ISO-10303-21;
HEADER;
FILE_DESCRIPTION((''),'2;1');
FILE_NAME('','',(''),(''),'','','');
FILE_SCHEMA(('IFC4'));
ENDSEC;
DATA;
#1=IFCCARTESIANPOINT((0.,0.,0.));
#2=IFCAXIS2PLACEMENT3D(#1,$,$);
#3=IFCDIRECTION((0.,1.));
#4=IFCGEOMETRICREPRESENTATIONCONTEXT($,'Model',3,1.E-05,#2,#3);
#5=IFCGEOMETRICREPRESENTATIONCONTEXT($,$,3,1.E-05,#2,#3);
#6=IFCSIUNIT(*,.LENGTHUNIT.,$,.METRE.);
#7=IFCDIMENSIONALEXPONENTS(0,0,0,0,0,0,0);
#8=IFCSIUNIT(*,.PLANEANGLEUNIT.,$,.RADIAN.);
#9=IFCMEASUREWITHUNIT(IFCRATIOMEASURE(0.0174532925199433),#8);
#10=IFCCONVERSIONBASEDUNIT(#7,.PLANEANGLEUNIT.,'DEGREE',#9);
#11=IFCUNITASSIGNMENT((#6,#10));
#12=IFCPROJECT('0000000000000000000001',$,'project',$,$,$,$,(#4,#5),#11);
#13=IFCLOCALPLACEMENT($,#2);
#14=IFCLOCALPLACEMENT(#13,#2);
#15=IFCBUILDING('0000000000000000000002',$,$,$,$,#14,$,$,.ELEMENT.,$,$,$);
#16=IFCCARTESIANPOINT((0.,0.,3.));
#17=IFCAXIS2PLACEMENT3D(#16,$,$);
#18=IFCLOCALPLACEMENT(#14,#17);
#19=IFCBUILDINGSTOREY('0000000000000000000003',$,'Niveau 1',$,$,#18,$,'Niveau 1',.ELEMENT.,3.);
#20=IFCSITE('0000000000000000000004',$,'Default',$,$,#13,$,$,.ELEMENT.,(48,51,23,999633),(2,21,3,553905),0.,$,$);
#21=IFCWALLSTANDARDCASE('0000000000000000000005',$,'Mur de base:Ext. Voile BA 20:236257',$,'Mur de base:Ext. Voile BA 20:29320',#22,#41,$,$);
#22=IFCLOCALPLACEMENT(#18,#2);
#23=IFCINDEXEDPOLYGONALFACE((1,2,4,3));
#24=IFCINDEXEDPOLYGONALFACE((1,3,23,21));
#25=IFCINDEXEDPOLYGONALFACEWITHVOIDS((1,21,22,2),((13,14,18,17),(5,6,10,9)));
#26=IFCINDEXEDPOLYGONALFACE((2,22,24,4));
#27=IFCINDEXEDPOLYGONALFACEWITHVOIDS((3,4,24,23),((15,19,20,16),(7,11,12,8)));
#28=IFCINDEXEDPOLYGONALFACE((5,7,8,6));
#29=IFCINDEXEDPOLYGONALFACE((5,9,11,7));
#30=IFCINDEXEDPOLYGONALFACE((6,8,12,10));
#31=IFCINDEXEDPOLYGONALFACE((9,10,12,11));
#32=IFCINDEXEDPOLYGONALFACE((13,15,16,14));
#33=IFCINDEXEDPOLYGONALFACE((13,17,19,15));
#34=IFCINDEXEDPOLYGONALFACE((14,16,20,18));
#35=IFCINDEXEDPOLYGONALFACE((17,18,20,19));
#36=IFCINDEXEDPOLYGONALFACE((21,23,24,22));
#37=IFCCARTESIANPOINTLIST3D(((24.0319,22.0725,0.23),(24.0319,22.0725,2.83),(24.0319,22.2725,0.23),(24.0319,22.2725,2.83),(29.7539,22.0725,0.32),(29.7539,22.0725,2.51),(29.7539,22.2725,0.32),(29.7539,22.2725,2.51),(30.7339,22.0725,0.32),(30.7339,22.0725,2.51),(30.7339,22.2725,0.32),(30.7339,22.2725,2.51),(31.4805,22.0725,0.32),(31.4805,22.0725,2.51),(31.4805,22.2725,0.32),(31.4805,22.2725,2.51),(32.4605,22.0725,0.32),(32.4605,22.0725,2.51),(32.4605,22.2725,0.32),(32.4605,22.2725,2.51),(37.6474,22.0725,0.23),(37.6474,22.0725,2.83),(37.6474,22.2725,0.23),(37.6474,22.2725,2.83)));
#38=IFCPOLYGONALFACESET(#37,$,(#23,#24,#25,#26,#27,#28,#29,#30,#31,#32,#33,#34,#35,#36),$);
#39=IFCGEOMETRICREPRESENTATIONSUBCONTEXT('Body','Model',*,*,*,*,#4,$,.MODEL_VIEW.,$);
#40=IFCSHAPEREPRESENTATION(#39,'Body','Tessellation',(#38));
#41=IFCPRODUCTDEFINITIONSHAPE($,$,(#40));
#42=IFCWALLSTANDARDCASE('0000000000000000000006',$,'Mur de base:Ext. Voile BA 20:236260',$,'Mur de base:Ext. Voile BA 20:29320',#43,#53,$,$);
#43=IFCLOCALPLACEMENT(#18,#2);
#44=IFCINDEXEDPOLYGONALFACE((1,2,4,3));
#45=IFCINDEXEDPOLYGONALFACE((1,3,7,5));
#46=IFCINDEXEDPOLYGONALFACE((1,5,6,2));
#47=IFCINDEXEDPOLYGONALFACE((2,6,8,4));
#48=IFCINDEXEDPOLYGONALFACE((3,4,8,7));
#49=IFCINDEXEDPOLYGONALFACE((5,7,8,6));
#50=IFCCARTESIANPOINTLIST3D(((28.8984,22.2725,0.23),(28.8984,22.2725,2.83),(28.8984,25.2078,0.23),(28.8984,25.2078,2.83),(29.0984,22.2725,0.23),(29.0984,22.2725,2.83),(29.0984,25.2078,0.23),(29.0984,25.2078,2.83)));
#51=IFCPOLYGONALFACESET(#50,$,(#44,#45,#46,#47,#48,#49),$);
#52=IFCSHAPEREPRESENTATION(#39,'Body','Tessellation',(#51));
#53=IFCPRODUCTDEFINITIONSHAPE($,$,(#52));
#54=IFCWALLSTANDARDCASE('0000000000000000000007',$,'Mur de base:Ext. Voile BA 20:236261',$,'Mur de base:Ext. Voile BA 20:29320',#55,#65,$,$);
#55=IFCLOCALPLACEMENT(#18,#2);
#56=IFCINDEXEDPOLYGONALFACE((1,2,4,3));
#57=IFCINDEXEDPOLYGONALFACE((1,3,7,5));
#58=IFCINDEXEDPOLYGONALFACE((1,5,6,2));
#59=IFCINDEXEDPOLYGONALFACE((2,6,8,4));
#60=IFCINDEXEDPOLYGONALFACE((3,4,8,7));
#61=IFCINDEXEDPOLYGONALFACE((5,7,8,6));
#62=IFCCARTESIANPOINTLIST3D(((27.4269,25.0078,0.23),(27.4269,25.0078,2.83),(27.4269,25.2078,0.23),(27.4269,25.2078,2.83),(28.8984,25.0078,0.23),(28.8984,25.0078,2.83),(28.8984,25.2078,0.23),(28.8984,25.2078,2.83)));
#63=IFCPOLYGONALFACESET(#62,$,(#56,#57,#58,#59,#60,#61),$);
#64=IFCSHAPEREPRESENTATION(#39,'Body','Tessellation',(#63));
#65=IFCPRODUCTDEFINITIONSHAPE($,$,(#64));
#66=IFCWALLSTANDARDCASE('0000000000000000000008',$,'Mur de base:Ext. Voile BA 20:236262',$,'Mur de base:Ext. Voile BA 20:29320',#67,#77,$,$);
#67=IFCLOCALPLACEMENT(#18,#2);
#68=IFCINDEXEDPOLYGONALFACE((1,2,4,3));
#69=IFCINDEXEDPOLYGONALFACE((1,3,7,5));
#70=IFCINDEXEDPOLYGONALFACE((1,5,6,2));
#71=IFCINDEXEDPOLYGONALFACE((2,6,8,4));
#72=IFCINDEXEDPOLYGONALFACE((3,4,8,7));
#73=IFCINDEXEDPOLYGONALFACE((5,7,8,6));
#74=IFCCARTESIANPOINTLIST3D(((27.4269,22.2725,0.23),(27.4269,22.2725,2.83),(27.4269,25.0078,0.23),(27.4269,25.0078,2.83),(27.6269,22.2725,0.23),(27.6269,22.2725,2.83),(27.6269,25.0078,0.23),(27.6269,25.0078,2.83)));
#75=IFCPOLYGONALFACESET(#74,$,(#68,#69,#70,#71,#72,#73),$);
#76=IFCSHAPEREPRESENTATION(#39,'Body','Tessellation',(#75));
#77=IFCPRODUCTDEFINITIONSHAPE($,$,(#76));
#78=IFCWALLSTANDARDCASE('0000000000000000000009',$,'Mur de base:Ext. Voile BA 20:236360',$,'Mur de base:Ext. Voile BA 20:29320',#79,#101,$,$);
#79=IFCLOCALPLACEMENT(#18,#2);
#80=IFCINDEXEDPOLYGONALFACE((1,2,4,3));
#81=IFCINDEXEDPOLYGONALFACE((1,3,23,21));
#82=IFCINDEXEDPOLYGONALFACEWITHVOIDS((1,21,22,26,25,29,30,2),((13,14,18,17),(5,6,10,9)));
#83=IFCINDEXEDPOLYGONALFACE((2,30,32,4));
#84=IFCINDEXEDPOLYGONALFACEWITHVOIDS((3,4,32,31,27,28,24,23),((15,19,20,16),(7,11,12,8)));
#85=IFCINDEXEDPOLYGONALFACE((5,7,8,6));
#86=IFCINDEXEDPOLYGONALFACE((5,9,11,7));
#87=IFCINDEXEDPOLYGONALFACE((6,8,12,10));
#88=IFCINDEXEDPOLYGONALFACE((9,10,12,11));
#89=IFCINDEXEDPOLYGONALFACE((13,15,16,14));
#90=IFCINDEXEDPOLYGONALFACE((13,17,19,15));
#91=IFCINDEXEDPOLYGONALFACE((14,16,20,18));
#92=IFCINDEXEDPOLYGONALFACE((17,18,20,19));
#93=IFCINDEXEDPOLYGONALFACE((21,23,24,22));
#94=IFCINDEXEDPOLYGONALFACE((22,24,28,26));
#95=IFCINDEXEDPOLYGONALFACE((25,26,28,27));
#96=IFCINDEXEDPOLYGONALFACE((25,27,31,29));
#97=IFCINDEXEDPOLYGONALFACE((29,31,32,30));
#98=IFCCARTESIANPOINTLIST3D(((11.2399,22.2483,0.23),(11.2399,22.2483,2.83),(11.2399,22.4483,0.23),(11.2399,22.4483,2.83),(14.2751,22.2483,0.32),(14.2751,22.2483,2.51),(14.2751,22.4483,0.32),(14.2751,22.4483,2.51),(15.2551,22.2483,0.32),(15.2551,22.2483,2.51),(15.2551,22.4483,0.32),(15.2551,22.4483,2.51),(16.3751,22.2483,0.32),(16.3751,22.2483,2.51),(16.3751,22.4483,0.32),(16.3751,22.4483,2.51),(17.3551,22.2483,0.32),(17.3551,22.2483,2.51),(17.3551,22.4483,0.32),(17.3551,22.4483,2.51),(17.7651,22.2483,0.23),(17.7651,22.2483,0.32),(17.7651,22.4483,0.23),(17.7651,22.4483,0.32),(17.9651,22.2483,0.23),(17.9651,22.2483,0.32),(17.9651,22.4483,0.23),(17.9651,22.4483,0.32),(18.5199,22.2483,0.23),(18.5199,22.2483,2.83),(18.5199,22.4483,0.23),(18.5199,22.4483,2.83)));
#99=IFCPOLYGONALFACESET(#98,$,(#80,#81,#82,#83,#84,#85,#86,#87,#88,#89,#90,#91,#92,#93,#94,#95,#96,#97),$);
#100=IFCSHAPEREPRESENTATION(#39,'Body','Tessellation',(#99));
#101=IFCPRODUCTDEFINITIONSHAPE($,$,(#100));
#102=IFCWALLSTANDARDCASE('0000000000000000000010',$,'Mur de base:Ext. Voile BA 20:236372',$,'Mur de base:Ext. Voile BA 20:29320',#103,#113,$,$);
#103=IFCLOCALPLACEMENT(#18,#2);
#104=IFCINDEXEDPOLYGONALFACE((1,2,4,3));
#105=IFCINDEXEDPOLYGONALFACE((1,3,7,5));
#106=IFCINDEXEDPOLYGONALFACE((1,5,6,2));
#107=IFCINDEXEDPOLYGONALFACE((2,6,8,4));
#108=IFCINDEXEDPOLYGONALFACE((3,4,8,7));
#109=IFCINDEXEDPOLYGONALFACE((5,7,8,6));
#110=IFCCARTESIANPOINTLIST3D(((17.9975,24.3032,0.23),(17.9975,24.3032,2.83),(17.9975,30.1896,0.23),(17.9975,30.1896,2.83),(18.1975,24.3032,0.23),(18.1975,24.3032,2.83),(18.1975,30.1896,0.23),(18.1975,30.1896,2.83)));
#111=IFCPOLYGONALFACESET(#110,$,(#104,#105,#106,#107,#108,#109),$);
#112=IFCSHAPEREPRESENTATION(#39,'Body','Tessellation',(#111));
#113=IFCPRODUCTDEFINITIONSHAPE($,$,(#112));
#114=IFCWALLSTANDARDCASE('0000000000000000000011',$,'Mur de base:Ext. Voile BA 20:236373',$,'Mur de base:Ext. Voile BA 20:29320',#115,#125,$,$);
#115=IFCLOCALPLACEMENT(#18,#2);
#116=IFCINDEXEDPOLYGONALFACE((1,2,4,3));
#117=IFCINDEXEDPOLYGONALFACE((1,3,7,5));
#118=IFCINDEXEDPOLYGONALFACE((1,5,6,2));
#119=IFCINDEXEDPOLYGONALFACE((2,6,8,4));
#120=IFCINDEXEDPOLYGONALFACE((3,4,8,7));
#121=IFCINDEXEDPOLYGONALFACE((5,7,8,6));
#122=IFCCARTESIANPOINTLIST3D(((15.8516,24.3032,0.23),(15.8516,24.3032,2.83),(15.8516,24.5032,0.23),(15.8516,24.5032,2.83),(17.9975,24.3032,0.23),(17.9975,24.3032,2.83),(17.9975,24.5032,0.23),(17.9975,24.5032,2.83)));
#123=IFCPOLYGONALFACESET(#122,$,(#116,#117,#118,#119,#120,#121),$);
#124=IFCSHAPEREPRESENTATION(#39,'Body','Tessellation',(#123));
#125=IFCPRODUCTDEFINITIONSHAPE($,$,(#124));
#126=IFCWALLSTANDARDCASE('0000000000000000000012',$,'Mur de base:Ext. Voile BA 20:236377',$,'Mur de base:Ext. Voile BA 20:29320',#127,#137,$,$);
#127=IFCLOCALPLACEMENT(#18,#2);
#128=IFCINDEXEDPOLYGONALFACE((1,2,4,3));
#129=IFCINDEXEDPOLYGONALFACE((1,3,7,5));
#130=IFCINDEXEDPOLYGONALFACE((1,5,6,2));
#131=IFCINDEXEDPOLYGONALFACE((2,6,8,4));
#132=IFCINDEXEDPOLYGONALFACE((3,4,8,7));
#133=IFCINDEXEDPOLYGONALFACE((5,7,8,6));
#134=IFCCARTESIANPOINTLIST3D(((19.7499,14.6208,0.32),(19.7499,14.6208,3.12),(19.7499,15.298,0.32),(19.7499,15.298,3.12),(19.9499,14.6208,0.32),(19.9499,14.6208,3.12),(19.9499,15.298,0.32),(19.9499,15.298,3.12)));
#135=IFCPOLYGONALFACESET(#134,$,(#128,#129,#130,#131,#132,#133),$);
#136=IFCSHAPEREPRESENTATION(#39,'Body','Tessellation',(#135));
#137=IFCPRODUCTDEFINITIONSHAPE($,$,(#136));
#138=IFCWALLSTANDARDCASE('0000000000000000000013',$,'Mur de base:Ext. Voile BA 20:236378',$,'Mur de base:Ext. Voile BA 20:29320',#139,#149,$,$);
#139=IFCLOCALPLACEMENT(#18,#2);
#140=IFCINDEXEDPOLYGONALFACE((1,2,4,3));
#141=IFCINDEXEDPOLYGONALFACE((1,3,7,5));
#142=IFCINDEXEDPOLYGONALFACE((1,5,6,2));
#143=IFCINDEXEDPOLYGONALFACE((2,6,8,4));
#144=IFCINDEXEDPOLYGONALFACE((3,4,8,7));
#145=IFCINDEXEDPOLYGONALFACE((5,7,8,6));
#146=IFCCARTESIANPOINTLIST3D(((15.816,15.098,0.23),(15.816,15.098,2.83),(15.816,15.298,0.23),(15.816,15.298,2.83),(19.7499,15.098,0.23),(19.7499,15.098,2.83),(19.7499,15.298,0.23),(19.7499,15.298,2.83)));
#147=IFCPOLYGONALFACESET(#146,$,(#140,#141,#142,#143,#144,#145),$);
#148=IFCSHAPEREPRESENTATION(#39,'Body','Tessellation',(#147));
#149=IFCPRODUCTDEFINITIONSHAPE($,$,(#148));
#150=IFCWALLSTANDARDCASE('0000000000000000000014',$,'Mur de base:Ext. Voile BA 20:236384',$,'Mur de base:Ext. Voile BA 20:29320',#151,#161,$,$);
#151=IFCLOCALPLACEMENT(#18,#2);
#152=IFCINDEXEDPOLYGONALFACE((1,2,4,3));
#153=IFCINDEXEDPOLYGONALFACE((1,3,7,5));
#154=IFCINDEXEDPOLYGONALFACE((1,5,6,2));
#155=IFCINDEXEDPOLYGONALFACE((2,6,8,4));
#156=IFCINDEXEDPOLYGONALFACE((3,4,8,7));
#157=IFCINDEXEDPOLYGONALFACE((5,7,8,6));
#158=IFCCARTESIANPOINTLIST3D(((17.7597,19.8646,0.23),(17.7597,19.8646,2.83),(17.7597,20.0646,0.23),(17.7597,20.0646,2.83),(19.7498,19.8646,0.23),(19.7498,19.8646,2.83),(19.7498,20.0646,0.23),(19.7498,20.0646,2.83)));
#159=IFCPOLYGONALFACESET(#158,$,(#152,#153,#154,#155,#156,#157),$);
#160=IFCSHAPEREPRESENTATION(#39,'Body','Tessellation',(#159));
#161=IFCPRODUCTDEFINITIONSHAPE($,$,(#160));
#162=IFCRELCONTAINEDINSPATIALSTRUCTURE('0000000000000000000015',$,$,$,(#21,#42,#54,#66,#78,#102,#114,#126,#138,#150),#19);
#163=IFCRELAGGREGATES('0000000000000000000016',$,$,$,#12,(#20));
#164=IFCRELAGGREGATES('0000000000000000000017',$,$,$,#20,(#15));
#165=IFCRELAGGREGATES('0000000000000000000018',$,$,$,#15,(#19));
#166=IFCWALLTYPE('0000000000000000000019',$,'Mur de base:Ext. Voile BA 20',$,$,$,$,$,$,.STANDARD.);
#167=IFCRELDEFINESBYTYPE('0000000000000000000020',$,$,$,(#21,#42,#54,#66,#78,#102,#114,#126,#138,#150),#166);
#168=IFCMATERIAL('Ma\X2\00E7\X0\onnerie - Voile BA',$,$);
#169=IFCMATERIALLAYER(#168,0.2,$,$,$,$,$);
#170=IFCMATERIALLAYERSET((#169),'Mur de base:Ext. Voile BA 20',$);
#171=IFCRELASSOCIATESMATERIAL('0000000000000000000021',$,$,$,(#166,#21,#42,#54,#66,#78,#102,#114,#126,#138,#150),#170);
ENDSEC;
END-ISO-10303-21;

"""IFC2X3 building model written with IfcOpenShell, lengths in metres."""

from ifc_helpers import new_model, entity, si_unit, converted_unit, direction, frame, frame_2d, origin, origin_2d_with_axis, place, context, subcontext, project, spatial, polyline, rectangle, extrude, clip, bounded_halfspace, material, layer, layer_set, layer_usage, type_object, element, save


model = new_model("IFC2X3")

# Units and contexts
model_context = context("Model", 3, precision=1e-05, world=origin(), true_north=direction((0.0, 1.0)))
context_of_model = context(None, 3, precision=1e-05, world=origin(), true_north=direction((0.0, 1.0)))
body_context = subcontext(model_context, "Body", "Model", "MODEL_VIEW")
ifc_project = project(units=[si_unit("LENGTHUNIT", "METRE"), converted_unit("PLANEANGLEUNIT", "DEGREE", entity("IfcRatioMeasure", 0.0174532925199433), si_unit("PLANEANGLEUNIT", "RADIAN"), dimensions=[0, 0, 0, 0, 0, 0, 0])], contexts=[model_context, context_of_model])

# Site, building, storey
site_placement = place(None, origin())
site = spatial("IfcSite", under=ifc_project, at=site_placement, Name="Default", CompositionType="ELEMENT", RefLatitude=(48, 51, 23, 999633), RefLongitude=(2, 21, 3, 553905), RefElevation=0.0)
building_placement = place(site_placement, origin())
building = spatial("IfcBuilding", under=site, at=building_placement, CompositionType="ELEMENT")
storey_placement = place(building_placement, frame((0.0, 0.0, 3.0)))
storey = spatial("IfcBuildingStorey", under=building, at=storey_placement, Name="Niveau 1", LongName="Niveau 1", CompositionType="ELEMENT", Elevation=3.0)

# Wall, openings
ifc_material = material(Name="Maçonnerie - Voile BA")
ifc_layer_1 = layer(ifc_material, 0.2)
ifc_layer_set_1 = layer_set([ifc_layer_1], Name="Mur de base:Ext. Voile BA 20")
ifc_layer_usage_1 = layer_usage(ifc_layer_set_1, "AXIS2", "NEGATIVE", 0.1)
wall_type_1 = type_object("IfcWallType", Name="Mur de base:Ext. Voile BA 20", PredefinedType="STANDARD", material=ifc_layer_set_1)
wall_1_placement = place(storey_placement, frame((24.0319, 22.1725, 0.23)))
wall_1 = element("IfcWallStandardCase", 1, at=wall_1_placement, inside=storey, type_object=wall_type_1, material=ifc_layer_usage_1, Name="Mur de base:Ext. Voile BA 20:236257", ObjectType="Mur de base:Ext. Voile BA 20:29320", context=body_context, shape_type="SweptSolid", body=[
    extrude(rectangle(XDim=13.6155, YDim=0.2, at=frame_2d((6.8077, 0.0), x_axis=(-1.0, 0.0))), origin(), (0.0, 0.0, 1.0), 2.6),
])
opening_1_placement = place(wall_1_placement, origin())
element("IfcOpeningElement", 2, at=opening_1_placement, cuts=wall_1, ObjectType="Opening", context=body_context, shape_type="SweptSolid", body=[
    extrude(rectangle(XDim=2.19, YDim=0.98, at=origin_2d_with_axis()), frame((7.9385, -0.1, 1.185), z_axis=(0.0, 1.0, 0.0), x_axis=(0.0, 0.0, -1.0)), (0.0, 0.0, 1.0), 0.2),
])
opening_2_placement = place(wall_1_placement, origin())
element("IfcOpeningElement", 3, at=opening_2_placement, cuts=wall_1, ObjectType="Opening", context=body_context, shape_type="SweptSolid", body=[
    extrude(rectangle(XDim=2.19, YDim=0.98, at=origin_2d_with_axis()), frame((6.212, -0.1, 1.185), z_axis=(0.0, 1.0, 0.0), x_axis=(0.0, 0.0, -1.0)), (0.0, 0.0, 1.0), 0.2),
])

# Walls
ifc_layer_usage_2 = layer_usage(ifc_layer_set_1, "AXIS2", "NEGATIVE", 0.1)
wall_2_placement = place(storey_placement, frame((28.9984, 22.2725, 0.23), z_axis=(0.0, 0.0, 1.0), x_axis=(0.0, 1.0, 0.0)))
element("IfcWallStandardCase", 4, at=wall_2_placement, inside=storey, type_object=wall_type_1, material=ifc_layer_usage_2, Name="Mur de base:Ext. Voile BA 20:236260", ObjectType="Mur de base:Ext. Voile BA 20:29320", context=body_context, shape_type="SweptSolid", body=[
    extrude(rectangle(XDim=2.9353, YDim=0.2, at=frame_2d((1.4677, 0.0), x_axis=(-1.0, 0.0))), origin(), (0.0, 0.0, 1.0), 2.6),
])
ifc_layer_usage_3 = layer_usage(ifc_layer_set_1, "AXIS2", "NEGATIVE", 0.1)
wall_3_placement = place(storey_placement, frame((28.8984, 25.1078, 0.23), z_axis=(0.0, 0.0, 1.0), x_axis=(-1.0, 0.0, 0.0)))
element("IfcWallStandardCase", 5, at=wall_3_placement, inside=storey, type_object=wall_type_1, material=ifc_layer_usage_3, Name="Mur de base:Ext. Voile BA 20:236261", ObjectType="Mur de base:Ext. Voile BA 20:29320", context=body_context, shape_type="SweptSolid", body=[
    extrude(rectangle(XDim=1.4714, YDim=0.2, at=frame_2d((0.7357, 0.0), x_axis=(-1.0, 0.0))), origin(), (0.0, 0.0, 1.0), 2.6),
])
ifc_layer_usage_4 = layer_usage(ifc_layer_set_1, "AXIS2", "NEGATIVE", 0.1)
wall_4_placement = place(storey_placement, frame((27.5269, 25.0078, 0.23), z_axis=(0.0, 0.0, 1.0), x_axis=(0.0, -1.0, 0.0)))
element("IfcWallStandardCase", 6, at=wall_4_placement, inside=storey, type_object=wall_type_1, material=ifc_layer_usage_4, Name="Mur de base:Ext. Voile BA 20:236262", ObjectType="Mur de base:Ext. Voile BA 20:29320", context=body_context, shape_type="SweptSolid", body=[
    extrude(rectangle(XDim=2.7353, YDim=0.2, at=frame_2d((1.3677, 0.0), x_axis=(-1.0, 0.0))), origin(), (0.0, 0.0, 1.0), 2.6),
])

# Wall, openings
ifc_layer_usage_5 = layer_usage(ifc_layer_set_1, "AXIS2", "NEGATIVE", 0.1)
wall_5_placement = place(storey_placement, frame((18.5199, 22.3483, 0.23), z_axis=(0.0, 0.0, 1.0), x_axis=(-1.0, 0.0, 0.0)))
wall_5 = element("IfcWallStandardCase", 7, at=wall_5_placement, inside=storey, type_object=wall_type_1, material=ifc_layer_usage_5, Name="Mur de base:Ext. Voile BA 20:236360", ObjectType="Mur de base:Ext. Voile BA 20:29320", context=body_context, shape_type="Clipping", body=[
    clip(extrude(rectangle(XDim=7.28, YDim=0.2, at=frame_2d((3.64, 0.0), x_axis=(-1.0, 0.0))), origin(), (0.0, 0.0, 1.0), 2.6), bounded_halfspace(frame((0.7548, 0.1, 0.09), z_axis=(0.0, 0.0, 1.0), x_axis=(-1.0, 0.0, 0.0)), True, frame((0.7548, 0.1, 0.09), z_axis=(0.0, 0.0, 1.0), x_axis=(-1.0, 0.0, 0.0)), polyline([(0.0, 0.0), (0.2, 0.0), (0.2, 0.2), (0.0, 0.2), (0.0, 0.0)]))),
])
opening_3_placement = place(wall_5_placement, origin())
element("IfcOpeningElement", 8, at=opening_3_placement, cuts=wall_5, ObjectType="Opening", context=body_context, shape_type="SweptSolid", body=[
    extrude(rectangle(XDim=2.19, YDim=0.98, at=origin_2d_with_axis()), frame((3.7548, -0.1, 1.185), z_axis=(0.0, 1.0, 0.0), x_axis=(0.0, 0.0, -1.0)), (0.0, 0.0, 1.0), 0.2),
])
opening_4_placement = place(wall_5_placement, origin())
element("IfcOpeningElement", 9, at=opening_4_placement, cuts=wall_5, ObjectType="Opening", context=body_context, shape_type="SweptSolid", body=[
    extrude(rectangle(XDim=2.19, YDim=0.98, at=frame_2d((0.0, 0.0), x_axis=(1.0, 0.0))), frame((1.6548, -0.1, 1.185), z_axis=(0.0, 1.0, 0.0), x_axis=(0.0, 0.0, -1.0)), (0.0, 0.0, 1.0), 0.2),
])

# Walls
ifc_layer_usage_6 = layer_usage(ifc_layer_set_1, "AXIS2", "NEGATIVE", 0.1)
wall_6_placement = place(storey_placement, frame((18.0975, 30.1896, 0.23), z_axis=(0.0, 0.0, 1.0), x_axis=(0.0, -1.0, 0.0)))
element("IfcWallStandardCase", 10, at=wall_6_placement, inside=storey, type_object=wall_type_1, material=ifc_layer_usage_6, Name="Mur de base:Ext. Voile BA 20:236372", ObjectType="Mur de base:Ext. Voile BA 20:29320", context=body_context, shape_type="SweptSolid", body=[
    extrude(rectangle(XDim=5.8865, YDim=0.2, at=frame_2d((2.9432, 0.0), x_axis=(-1.0, 0.0))), origin(), (0.0, 0.0, 1.0), 2.6),
])
ifc_layer_usage_7 = layer_usage(ifc_layer_set_1, "AXIS2", "NEGATIVE", 0.1)
wall_7_placement = place(storey_placement, frame((17.9975, 24.4032, 0.23), z_axis=(0.0, 0.0, 1.0), x_axis=(-1.0, 0.0, 0.0)))
element("IfcWallStandardCase", 11, at=wall_7_placement, inside=storey, type_object=wall_type_1, material=ifc_layer_usage_7, Name="Mur de base:Ext. Voile BA 20:236373", ObjectType="Mur de base:Ext. Voile BA 20:29320", context=body_context, shape_type="SweptSolid", body=[
    extrude(rectangle(XDim=2.146, YDim=0.2, at=frame_2d((1.073, 0.0), x_axis=(-1.0, 0.0))), origin(), (0.0, 0.0, 1.0), 2.6),
])
ifc_layer_usage_8 = layer_usage(ifc_layer_set_1, "AXIS2", "NEGATIVE", 0.1)
wall_8_placement = place(storey_placement, frame((19.8499, 14.6208, 0.32), z_axis=(0.0, 0.0, 1.0), x_axis=(0.0, 1.0, 0.0)))
element("IfcWallStandardCase", 12, at=wall_8_placement, inside=storey, type_object=wall_type_1, material=ifc_layer_usage_8, Name="Mur de base:Ext. Voile BA 20:236377", ObjectType="Mur de base:Ext. Voile BA 20:29320", context=body_context, shape_type="SweptSolid", body=[
    extrude(rectangle(XDim=0.6771, YDim=0.2, at=frame_2d((0.3386, 0.0), x_axis=(-1.0, 0.0))), origin(), (0.0, 0.0, 1.0), 2.8),
])
ifc_layer_usage_9 = layer_usage(ifc_layer_set_1, "AXIS2", "NEGATIVE", 0.1)
wall_9_placement = place(storey_placement, frame((19.7499, 15.198, 0.23), z_axis=(0.0, 0.0, 1.0), x_axis=(-1.0, 0.0, 0.0)))
element("IfcWallStandardCase", 13, at=wall_9_placement, inside=storey, type_object=wall_type_1, material=ifc_layer_usage_9, Name="Mur de base:Ext. Voile BA 20:236378", ObjectType="Mur de base:Ext. Voile BA 20:29320", context=body_context, shape_type="SweptSolid", body=[
    extrude(rectangle(XDim=3.9339, YDim=0.2, at=frame_2d((1.967, 0.0), x_axis=(-1.0, 0.0))), origin(), (0.0, 0.0, 1.0), 2.6),
])
ifc_layer_usage_10 = layer_usage(ifc_layer_set_1, "AXIS2", "NEGATIVE", 0.1)
wall_10_placement = place(storey_placement, frame((19.7498, 19.9646, 0.23), z_axis=(0.0, 0.0, 1.0), x_axis=(-1.0, 0.0, 0.0)))
element("IfcWallStandardCase", 14, at=wall_10_placement, inside=storey, type_object=wall_type_1, material=ifc_layer_usage_10, Name="Mur de base:Ext. Voile BA 20:236384", ObjectType="Mur de base:Ext. Voile BA 20:29320", context=body_context, shape_type="SweptSolid", body=[
    extrude(rectangle(XDim=1.9901, YDim=0.2, at=frame_2d((0.9951, 0.0), x_axis=(-1.0, 0.0))), origin(), (0.0, 0.0, 1.0), 2.6),
])

save(model, "model.ifc")
